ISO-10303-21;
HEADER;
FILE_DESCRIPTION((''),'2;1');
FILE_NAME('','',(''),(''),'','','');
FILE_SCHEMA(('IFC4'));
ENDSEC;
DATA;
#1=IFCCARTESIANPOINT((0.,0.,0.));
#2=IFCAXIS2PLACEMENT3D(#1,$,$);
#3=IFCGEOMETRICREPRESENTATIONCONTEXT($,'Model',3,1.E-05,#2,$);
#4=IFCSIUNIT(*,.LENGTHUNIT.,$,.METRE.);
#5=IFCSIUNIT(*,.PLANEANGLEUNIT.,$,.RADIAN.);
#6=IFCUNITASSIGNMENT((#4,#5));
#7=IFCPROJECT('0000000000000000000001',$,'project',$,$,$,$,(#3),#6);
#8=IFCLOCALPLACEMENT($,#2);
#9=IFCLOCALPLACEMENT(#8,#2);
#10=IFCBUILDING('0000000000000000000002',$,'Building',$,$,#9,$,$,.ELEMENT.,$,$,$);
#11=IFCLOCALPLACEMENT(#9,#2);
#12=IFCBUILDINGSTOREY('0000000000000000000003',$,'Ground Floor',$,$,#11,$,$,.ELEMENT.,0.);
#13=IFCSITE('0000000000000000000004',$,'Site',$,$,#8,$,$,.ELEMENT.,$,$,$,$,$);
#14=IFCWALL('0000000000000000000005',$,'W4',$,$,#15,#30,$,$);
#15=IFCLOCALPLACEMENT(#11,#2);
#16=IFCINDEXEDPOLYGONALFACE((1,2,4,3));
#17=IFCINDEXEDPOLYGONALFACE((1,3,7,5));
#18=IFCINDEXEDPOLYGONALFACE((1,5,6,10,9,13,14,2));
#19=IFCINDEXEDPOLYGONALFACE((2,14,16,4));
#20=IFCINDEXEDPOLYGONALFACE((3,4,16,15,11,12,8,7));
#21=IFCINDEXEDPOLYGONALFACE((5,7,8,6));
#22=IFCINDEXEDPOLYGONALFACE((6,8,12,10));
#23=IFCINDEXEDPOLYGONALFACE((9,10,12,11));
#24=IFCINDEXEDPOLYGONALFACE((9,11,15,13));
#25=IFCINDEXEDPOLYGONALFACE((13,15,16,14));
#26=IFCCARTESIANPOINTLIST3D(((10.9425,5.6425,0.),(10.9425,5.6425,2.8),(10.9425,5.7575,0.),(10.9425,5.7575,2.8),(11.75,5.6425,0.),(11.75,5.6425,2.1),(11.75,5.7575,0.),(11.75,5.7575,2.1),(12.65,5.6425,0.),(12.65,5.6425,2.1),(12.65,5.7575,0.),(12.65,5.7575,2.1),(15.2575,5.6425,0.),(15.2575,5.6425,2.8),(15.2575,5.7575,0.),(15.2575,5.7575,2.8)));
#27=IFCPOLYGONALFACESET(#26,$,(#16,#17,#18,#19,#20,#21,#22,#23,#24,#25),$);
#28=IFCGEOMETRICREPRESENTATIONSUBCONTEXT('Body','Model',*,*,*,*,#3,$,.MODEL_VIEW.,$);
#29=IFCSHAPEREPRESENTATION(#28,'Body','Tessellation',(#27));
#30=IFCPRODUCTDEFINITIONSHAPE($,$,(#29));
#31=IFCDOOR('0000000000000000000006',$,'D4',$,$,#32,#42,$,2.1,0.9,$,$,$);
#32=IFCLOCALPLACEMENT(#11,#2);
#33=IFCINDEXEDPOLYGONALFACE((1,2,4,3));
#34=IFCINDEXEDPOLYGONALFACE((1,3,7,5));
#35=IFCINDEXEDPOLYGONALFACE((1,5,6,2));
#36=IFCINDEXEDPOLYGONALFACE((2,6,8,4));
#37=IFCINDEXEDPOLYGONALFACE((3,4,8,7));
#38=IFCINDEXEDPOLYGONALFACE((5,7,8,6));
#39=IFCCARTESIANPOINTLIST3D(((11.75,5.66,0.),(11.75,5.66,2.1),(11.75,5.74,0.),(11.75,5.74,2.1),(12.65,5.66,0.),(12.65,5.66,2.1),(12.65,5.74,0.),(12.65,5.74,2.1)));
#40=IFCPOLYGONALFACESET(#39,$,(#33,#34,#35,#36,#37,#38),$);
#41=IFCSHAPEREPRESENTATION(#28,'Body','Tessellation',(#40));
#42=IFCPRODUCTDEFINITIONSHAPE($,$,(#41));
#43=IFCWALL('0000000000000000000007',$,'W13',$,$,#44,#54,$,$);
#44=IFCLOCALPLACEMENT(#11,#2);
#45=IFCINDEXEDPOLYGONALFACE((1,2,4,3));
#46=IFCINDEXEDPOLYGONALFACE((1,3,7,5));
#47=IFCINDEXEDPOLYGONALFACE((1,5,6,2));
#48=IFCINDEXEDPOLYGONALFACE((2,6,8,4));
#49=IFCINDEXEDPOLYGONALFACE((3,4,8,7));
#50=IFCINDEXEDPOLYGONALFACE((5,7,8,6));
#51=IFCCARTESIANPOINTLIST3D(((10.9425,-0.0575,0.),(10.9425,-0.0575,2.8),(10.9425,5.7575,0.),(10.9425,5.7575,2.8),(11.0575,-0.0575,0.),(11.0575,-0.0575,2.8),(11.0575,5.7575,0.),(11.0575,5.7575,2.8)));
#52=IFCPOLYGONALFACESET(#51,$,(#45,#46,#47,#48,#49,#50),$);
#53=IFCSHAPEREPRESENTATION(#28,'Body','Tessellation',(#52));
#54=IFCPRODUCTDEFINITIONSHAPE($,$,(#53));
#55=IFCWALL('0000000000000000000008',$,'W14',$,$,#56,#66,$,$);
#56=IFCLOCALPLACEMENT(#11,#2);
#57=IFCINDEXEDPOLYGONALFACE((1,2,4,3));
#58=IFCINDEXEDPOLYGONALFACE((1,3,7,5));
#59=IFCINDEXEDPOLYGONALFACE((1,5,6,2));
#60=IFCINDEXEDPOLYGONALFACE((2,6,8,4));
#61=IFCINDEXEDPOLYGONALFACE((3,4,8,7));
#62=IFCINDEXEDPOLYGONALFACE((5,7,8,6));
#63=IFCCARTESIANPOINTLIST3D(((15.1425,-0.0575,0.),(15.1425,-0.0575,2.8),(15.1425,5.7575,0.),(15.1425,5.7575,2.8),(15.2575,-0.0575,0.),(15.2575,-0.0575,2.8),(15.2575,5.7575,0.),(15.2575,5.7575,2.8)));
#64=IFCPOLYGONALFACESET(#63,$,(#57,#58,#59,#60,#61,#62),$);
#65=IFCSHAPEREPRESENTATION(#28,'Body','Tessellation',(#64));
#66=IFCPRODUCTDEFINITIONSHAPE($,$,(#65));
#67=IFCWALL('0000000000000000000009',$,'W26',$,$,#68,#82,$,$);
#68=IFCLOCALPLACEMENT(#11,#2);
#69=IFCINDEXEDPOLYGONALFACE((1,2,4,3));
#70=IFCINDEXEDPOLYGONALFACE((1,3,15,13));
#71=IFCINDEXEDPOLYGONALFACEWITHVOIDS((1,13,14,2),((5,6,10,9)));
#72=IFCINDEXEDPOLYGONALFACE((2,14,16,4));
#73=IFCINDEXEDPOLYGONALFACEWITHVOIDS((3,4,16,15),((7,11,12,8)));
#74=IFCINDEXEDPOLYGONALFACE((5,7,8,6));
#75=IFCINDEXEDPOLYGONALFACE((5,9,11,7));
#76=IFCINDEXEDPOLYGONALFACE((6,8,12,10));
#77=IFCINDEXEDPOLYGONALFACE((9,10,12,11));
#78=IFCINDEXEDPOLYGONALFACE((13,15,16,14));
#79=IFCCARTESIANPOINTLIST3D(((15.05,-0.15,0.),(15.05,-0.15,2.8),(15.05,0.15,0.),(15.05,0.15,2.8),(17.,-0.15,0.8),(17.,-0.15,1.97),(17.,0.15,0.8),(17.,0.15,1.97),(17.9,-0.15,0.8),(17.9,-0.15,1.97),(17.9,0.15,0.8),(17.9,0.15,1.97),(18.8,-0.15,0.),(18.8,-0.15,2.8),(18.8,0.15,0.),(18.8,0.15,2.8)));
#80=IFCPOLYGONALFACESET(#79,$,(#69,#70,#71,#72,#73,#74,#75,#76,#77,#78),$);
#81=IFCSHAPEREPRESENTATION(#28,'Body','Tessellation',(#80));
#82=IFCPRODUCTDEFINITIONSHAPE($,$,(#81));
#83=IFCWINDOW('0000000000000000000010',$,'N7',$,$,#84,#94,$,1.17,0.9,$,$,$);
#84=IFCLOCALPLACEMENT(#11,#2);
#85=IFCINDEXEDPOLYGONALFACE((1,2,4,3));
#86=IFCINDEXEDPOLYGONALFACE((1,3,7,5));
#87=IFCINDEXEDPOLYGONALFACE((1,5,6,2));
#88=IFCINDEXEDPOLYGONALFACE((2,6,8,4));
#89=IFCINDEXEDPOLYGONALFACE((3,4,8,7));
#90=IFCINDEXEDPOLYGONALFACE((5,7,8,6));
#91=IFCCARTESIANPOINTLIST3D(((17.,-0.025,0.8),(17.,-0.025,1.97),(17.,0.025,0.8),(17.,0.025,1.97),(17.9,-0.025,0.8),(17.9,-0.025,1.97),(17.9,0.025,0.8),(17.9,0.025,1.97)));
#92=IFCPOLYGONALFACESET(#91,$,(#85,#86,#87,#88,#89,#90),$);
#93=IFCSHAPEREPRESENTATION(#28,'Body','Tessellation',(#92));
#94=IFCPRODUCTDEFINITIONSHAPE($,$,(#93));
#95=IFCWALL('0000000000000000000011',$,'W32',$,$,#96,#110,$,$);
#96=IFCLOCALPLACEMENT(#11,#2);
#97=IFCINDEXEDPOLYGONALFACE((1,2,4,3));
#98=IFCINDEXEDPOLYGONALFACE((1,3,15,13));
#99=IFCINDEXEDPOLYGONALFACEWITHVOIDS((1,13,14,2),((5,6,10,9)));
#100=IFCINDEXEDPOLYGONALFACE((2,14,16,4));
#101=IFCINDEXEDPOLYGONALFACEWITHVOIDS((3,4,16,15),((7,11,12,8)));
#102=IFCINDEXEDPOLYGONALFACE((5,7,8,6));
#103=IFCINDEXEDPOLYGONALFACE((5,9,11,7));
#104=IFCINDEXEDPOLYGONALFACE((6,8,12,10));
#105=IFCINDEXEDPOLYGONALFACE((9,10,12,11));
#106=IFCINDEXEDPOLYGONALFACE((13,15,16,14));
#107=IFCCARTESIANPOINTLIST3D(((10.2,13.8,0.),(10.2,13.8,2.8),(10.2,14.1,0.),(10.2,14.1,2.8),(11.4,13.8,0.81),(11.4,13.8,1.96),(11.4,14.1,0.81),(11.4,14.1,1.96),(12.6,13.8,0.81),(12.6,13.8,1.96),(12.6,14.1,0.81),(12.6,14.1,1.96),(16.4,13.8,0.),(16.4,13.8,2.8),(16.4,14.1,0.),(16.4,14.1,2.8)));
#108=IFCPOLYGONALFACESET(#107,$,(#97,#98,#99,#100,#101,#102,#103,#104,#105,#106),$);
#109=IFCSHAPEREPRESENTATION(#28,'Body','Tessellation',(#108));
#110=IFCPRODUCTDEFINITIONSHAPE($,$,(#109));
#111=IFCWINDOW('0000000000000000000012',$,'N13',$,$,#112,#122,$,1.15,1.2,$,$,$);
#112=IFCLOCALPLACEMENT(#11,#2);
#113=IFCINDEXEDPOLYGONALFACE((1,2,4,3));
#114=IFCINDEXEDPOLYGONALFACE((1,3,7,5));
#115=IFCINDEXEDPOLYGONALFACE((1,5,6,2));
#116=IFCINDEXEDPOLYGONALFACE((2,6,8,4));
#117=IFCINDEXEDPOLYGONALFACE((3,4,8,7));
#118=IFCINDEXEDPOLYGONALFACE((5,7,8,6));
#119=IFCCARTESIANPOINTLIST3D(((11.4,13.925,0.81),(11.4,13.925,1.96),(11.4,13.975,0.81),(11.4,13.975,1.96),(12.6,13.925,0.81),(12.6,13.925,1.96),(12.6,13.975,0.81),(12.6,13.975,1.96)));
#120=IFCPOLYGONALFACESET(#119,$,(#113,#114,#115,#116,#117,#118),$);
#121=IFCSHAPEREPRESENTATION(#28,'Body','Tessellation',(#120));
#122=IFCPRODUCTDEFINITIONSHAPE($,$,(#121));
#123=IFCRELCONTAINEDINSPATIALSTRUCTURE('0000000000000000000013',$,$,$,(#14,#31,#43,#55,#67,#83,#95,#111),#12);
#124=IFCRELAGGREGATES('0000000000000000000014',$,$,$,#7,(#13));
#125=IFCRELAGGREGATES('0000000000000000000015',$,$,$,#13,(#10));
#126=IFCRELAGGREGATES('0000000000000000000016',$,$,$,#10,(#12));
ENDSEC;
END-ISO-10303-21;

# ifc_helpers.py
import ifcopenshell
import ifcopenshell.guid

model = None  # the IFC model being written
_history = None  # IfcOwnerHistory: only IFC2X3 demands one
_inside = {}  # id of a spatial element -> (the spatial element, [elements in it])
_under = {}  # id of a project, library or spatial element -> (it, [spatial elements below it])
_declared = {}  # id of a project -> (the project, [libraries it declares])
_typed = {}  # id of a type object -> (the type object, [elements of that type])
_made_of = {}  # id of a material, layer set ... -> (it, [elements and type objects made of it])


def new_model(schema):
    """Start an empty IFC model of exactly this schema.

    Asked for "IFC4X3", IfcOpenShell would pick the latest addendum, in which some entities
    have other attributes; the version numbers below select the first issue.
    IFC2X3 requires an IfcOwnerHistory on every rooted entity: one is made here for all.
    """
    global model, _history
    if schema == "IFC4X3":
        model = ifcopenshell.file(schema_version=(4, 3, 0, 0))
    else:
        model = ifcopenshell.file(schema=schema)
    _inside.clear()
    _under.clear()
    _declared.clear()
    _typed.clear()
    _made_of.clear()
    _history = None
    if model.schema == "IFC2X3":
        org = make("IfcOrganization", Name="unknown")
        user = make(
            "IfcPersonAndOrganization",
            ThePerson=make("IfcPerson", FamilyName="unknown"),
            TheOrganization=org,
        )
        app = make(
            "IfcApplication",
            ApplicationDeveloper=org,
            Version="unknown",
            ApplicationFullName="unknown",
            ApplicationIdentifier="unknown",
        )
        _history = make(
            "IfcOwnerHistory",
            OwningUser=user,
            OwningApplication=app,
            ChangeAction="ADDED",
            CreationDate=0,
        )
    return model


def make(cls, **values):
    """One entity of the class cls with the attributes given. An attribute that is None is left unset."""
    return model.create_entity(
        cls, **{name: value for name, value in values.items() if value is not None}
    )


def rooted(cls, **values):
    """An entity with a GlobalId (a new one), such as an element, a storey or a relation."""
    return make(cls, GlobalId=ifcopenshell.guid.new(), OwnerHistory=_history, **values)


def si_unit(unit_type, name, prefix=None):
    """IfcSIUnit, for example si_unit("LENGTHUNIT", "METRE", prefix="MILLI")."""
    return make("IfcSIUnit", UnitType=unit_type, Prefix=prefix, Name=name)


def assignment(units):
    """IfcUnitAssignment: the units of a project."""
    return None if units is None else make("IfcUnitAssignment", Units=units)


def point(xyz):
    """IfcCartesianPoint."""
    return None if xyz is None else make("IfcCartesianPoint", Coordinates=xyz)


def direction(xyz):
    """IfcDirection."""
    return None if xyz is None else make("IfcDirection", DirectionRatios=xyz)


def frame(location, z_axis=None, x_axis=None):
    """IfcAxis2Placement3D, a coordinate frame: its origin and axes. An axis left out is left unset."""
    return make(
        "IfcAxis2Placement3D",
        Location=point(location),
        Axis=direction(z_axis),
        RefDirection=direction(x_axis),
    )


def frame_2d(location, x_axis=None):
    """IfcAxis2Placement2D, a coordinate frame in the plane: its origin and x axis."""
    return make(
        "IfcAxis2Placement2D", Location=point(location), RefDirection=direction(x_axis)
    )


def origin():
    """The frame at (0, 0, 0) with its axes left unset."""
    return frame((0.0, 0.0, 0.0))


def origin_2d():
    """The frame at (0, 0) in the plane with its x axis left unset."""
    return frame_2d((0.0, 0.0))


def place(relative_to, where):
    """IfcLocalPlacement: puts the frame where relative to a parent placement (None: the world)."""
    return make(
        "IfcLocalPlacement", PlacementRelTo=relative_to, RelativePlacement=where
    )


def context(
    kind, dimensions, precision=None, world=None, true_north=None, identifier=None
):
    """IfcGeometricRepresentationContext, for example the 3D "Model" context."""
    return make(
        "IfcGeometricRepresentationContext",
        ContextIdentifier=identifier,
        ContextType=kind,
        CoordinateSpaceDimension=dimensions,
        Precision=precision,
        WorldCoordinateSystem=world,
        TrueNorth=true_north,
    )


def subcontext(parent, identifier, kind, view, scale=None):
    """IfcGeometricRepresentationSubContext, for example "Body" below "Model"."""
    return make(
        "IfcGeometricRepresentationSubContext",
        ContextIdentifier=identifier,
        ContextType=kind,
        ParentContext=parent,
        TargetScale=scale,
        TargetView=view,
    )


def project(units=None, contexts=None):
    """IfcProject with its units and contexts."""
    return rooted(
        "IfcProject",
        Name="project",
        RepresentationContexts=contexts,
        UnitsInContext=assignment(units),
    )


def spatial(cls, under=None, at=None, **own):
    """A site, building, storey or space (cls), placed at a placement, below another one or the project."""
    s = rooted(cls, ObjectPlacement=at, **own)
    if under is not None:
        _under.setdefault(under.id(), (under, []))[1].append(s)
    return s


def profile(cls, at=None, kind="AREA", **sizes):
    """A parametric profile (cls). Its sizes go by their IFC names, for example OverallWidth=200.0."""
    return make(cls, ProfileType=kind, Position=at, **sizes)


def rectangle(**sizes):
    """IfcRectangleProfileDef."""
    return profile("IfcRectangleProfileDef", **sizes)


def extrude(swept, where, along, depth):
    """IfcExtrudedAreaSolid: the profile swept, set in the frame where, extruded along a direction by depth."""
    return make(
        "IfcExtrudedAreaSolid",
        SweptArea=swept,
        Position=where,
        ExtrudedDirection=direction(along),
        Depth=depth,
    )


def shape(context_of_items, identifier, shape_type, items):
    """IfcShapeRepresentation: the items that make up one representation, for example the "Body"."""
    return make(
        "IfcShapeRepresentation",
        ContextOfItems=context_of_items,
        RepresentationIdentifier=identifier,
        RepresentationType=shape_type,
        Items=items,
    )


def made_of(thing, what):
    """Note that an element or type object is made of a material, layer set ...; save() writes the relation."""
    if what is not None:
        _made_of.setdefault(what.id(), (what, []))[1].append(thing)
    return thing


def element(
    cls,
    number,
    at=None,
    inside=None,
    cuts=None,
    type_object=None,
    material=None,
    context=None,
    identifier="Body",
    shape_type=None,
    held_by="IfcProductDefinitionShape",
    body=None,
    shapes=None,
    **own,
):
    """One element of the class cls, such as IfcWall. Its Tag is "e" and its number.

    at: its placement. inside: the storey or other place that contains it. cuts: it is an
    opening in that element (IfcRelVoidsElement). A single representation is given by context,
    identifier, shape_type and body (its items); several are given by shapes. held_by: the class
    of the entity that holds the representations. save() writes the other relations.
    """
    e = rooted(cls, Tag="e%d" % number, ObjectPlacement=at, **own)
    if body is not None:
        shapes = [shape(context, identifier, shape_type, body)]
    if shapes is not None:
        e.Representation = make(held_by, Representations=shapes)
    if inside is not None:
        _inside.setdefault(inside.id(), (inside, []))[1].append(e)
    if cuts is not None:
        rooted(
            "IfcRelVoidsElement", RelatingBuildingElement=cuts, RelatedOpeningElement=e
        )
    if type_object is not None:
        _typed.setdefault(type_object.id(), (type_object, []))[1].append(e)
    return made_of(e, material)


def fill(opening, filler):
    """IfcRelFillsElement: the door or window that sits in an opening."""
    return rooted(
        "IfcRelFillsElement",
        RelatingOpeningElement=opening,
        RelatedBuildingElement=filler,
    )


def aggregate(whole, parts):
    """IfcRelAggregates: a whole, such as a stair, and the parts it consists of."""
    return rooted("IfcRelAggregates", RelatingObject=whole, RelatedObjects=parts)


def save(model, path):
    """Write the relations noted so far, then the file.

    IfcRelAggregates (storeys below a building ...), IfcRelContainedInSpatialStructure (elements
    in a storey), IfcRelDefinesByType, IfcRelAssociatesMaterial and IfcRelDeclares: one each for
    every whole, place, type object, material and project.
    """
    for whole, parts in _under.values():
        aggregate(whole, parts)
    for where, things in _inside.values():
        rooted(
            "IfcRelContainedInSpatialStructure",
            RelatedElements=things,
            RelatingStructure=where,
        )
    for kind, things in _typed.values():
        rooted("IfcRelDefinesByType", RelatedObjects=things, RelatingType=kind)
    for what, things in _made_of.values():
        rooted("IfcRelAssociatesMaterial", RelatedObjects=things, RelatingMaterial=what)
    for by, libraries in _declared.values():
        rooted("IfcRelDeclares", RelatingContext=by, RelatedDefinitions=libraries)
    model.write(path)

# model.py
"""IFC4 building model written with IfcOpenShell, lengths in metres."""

from ifc_helpers import new_model, si_unit, frame, frame_2d, origin, origin_2d, place, context, subcontext, project, spatial, rectangle, extrude, element, fill, save


model = new_model("IFC4")

# Units and contexts
model_context = context("Model", 3, precision=1e-05, world=origin())
body_context = subcontext(model_context, "Body", "Model", "MODEL_VIEW")
ifc_project = project(units=[si_unit("LENGTHUNIT", "METRE"), si_unit("PLANEANGLEUNIT", "RADIAN")], contexts=[model_context])

# Site, building, storey
site_placement = place(None, origin())
site = spatial("IfcSite", under=ifc_project, at=site_placement, Name="Site", CompositionType="ELEMENT")
building_placement = place(site_placement, origin())
building = spatial("IfcBuilding", under=site, at=building_placement, Name="Building", CompositionType="ELEMENT")
storey_placement = place(building_placement, origin())
storey = spatial("IfcBuildingStorey", under=building, at=storey_placement, Name="Ground Floor", CompositionType="ELEMENT", Elevation=0.0)

# Wall, opening, door
wall_1_placement = place(storey_placement, frame((11.0, 5.7, 0.0), x_axis=(1.0, 0.0, 0.0)))
wall_1 = element("IfcWall", 1, at=wall_1_placement, inside=storey, Name="W4", context=body_context, shape_type="SweptSolid", body=[
    extrude(rectangle(XDim=4.315, YDim=0.115, at=frame_2d((2.1, 0.0))), origin(), (0.0, 0.0, 1.0), 2.8),
])
opening_1_placement = place(wall_1_placement, frame((1.2, 0.0, 0.0)))
opening_1 = element("IfcOpeningElement", 2, at=opening_1_placement, cuts=wall_1, context=body_context, shape_type="SweptSolid", body=[
    extrude(rectangle(XDim=0.9, YDim=0.215, at=origin_2d()), origin(), (0.0, 0.0, 1.0), 2.1),
])
door_1_placement = place(opening_1_placement, origin())
door_1 = element("IfcDoor", 3, at=door_1_placement, inside=storey, Name="D4", OverallHeight=2.1, OverallWidth=0.9, context=body_context, shape_type="SweptSolid", body=[
    extrude(rectangle(XDim=0.9, YDim=0.08, at=origin_2d()), origin(), (0.0, 0.0, 1.0), 2.1),
])
fill(opening_1, door_1)

# Walls
for number, where, x_axis, name in (
    (4, (11.0, 0.0, 0.0), (0.0, 1.0, 0.0), "W13"),
    (5, (15.2, 0.0, 0.0), (0.0, 1.0, 0.0), "W14"),
):
    element("IfcWall", number, at=place(storey_placement, frame(where, x_axis=x_axis)), inside=storey, Name=name, context=body_context, shape_type="SweptSolid", body=[
        extrude(rectangle(XDim=5.815, YDim=0.115, at=frame_2d((2.85, 0.0))), origin(), (0.0, 0.0, 1.0), 2.8),
    ])

# Walls, openings, windows
wall_2_placement = place(storey_placement, frame((15.2, 0.0, 0.0), x_axis=(1.0, 0.0, 0.0)))
wall_2 = element("IfcWall", 6, at=wall_2_placement, inside=storey, Name="W26", context=body_context, shape_type="SweptSolid", body=[
    extrude(rectangle(XDim=3.75, YDim=0.3, at=frame_2d((1.725, 0.0))), origin(), (0.0, 0.0, 1.0), 2.8),
])
opening_2_placement = place(wall_2_placement, frame((2.25, 0.0, 0.8)))
opening_2 = element("IfcOpeningElement", 7, at=opening_2_placement, cuts=wall_2, context=body_context, shape_type="SweptSolid", body=[
    extrude(rectangle(XDim=0.9, YDim=0.4, at=origin_2d()), origin(), (0.0, 0.0, 1.0), 1.17),
])
window_1_placement = place(opening_2_placement, origin())
window_1 = element("IfcWindow", 8, at=window_1_placement, inside=storey, Name="N7", OverallHeight=1.17, OverallWidth=0.9, context=body_context, shape_type="SweptSolid", body=[
    extrude(rectangle(XDim=0.9, YDim=0.05, at=origin_2d()), origin(), (0.0, 0.0, 1.0), 1.17),
])
fill(opening_2, window_1)
wall_3_placement = place(storey_placement, frame((10.35, 13.95, 0.0), x_axis=(1.0, 0.0, 0.0)))
wall_3 = element("IfcWall", 9, at=wall_3_placement, inside=storey, Name="W32", context=body_context, shape_type="SweptSolid", body=[
    extrude(rectangle(XDim=6.2, YDim=0.3, at=frame_2d((2.95, 0.0))), origin(), (0.0, 0.0, 1.0), 2.8),
])
opening_3_placement = place(wall_3_placement, frame((1.65, 0.0, 0.81)))
opening_3 = element("IfcOpeningElement", 10, at=opening_3_placement, cuts=wall_3, context=body_context, shape_type="SweptSolid", body=[
    extrude(rectangle(XDim=1.2, YDim=0.4, at=origin_2d()), origin(), (0.0, 0.0, 1.0), 1.15),
])
window_2_placement = place(opening_3_placement, origin())
window_2 = element("IfcWindow", 11, at=window_2_placement, inside=storey, Name="N13", OverallHeight=1.15, OverallWidth=1.2, context=body_context, shape_type="SweptSolid", body=[
    extrude(rectangle(XDim=1.2, YDim=0.05, at=origin_2d()), origin(), (0.0, 0.0, 1.0), 1.15),
])
fill(opening_3, window_2)

save(model, "model.ifc")
